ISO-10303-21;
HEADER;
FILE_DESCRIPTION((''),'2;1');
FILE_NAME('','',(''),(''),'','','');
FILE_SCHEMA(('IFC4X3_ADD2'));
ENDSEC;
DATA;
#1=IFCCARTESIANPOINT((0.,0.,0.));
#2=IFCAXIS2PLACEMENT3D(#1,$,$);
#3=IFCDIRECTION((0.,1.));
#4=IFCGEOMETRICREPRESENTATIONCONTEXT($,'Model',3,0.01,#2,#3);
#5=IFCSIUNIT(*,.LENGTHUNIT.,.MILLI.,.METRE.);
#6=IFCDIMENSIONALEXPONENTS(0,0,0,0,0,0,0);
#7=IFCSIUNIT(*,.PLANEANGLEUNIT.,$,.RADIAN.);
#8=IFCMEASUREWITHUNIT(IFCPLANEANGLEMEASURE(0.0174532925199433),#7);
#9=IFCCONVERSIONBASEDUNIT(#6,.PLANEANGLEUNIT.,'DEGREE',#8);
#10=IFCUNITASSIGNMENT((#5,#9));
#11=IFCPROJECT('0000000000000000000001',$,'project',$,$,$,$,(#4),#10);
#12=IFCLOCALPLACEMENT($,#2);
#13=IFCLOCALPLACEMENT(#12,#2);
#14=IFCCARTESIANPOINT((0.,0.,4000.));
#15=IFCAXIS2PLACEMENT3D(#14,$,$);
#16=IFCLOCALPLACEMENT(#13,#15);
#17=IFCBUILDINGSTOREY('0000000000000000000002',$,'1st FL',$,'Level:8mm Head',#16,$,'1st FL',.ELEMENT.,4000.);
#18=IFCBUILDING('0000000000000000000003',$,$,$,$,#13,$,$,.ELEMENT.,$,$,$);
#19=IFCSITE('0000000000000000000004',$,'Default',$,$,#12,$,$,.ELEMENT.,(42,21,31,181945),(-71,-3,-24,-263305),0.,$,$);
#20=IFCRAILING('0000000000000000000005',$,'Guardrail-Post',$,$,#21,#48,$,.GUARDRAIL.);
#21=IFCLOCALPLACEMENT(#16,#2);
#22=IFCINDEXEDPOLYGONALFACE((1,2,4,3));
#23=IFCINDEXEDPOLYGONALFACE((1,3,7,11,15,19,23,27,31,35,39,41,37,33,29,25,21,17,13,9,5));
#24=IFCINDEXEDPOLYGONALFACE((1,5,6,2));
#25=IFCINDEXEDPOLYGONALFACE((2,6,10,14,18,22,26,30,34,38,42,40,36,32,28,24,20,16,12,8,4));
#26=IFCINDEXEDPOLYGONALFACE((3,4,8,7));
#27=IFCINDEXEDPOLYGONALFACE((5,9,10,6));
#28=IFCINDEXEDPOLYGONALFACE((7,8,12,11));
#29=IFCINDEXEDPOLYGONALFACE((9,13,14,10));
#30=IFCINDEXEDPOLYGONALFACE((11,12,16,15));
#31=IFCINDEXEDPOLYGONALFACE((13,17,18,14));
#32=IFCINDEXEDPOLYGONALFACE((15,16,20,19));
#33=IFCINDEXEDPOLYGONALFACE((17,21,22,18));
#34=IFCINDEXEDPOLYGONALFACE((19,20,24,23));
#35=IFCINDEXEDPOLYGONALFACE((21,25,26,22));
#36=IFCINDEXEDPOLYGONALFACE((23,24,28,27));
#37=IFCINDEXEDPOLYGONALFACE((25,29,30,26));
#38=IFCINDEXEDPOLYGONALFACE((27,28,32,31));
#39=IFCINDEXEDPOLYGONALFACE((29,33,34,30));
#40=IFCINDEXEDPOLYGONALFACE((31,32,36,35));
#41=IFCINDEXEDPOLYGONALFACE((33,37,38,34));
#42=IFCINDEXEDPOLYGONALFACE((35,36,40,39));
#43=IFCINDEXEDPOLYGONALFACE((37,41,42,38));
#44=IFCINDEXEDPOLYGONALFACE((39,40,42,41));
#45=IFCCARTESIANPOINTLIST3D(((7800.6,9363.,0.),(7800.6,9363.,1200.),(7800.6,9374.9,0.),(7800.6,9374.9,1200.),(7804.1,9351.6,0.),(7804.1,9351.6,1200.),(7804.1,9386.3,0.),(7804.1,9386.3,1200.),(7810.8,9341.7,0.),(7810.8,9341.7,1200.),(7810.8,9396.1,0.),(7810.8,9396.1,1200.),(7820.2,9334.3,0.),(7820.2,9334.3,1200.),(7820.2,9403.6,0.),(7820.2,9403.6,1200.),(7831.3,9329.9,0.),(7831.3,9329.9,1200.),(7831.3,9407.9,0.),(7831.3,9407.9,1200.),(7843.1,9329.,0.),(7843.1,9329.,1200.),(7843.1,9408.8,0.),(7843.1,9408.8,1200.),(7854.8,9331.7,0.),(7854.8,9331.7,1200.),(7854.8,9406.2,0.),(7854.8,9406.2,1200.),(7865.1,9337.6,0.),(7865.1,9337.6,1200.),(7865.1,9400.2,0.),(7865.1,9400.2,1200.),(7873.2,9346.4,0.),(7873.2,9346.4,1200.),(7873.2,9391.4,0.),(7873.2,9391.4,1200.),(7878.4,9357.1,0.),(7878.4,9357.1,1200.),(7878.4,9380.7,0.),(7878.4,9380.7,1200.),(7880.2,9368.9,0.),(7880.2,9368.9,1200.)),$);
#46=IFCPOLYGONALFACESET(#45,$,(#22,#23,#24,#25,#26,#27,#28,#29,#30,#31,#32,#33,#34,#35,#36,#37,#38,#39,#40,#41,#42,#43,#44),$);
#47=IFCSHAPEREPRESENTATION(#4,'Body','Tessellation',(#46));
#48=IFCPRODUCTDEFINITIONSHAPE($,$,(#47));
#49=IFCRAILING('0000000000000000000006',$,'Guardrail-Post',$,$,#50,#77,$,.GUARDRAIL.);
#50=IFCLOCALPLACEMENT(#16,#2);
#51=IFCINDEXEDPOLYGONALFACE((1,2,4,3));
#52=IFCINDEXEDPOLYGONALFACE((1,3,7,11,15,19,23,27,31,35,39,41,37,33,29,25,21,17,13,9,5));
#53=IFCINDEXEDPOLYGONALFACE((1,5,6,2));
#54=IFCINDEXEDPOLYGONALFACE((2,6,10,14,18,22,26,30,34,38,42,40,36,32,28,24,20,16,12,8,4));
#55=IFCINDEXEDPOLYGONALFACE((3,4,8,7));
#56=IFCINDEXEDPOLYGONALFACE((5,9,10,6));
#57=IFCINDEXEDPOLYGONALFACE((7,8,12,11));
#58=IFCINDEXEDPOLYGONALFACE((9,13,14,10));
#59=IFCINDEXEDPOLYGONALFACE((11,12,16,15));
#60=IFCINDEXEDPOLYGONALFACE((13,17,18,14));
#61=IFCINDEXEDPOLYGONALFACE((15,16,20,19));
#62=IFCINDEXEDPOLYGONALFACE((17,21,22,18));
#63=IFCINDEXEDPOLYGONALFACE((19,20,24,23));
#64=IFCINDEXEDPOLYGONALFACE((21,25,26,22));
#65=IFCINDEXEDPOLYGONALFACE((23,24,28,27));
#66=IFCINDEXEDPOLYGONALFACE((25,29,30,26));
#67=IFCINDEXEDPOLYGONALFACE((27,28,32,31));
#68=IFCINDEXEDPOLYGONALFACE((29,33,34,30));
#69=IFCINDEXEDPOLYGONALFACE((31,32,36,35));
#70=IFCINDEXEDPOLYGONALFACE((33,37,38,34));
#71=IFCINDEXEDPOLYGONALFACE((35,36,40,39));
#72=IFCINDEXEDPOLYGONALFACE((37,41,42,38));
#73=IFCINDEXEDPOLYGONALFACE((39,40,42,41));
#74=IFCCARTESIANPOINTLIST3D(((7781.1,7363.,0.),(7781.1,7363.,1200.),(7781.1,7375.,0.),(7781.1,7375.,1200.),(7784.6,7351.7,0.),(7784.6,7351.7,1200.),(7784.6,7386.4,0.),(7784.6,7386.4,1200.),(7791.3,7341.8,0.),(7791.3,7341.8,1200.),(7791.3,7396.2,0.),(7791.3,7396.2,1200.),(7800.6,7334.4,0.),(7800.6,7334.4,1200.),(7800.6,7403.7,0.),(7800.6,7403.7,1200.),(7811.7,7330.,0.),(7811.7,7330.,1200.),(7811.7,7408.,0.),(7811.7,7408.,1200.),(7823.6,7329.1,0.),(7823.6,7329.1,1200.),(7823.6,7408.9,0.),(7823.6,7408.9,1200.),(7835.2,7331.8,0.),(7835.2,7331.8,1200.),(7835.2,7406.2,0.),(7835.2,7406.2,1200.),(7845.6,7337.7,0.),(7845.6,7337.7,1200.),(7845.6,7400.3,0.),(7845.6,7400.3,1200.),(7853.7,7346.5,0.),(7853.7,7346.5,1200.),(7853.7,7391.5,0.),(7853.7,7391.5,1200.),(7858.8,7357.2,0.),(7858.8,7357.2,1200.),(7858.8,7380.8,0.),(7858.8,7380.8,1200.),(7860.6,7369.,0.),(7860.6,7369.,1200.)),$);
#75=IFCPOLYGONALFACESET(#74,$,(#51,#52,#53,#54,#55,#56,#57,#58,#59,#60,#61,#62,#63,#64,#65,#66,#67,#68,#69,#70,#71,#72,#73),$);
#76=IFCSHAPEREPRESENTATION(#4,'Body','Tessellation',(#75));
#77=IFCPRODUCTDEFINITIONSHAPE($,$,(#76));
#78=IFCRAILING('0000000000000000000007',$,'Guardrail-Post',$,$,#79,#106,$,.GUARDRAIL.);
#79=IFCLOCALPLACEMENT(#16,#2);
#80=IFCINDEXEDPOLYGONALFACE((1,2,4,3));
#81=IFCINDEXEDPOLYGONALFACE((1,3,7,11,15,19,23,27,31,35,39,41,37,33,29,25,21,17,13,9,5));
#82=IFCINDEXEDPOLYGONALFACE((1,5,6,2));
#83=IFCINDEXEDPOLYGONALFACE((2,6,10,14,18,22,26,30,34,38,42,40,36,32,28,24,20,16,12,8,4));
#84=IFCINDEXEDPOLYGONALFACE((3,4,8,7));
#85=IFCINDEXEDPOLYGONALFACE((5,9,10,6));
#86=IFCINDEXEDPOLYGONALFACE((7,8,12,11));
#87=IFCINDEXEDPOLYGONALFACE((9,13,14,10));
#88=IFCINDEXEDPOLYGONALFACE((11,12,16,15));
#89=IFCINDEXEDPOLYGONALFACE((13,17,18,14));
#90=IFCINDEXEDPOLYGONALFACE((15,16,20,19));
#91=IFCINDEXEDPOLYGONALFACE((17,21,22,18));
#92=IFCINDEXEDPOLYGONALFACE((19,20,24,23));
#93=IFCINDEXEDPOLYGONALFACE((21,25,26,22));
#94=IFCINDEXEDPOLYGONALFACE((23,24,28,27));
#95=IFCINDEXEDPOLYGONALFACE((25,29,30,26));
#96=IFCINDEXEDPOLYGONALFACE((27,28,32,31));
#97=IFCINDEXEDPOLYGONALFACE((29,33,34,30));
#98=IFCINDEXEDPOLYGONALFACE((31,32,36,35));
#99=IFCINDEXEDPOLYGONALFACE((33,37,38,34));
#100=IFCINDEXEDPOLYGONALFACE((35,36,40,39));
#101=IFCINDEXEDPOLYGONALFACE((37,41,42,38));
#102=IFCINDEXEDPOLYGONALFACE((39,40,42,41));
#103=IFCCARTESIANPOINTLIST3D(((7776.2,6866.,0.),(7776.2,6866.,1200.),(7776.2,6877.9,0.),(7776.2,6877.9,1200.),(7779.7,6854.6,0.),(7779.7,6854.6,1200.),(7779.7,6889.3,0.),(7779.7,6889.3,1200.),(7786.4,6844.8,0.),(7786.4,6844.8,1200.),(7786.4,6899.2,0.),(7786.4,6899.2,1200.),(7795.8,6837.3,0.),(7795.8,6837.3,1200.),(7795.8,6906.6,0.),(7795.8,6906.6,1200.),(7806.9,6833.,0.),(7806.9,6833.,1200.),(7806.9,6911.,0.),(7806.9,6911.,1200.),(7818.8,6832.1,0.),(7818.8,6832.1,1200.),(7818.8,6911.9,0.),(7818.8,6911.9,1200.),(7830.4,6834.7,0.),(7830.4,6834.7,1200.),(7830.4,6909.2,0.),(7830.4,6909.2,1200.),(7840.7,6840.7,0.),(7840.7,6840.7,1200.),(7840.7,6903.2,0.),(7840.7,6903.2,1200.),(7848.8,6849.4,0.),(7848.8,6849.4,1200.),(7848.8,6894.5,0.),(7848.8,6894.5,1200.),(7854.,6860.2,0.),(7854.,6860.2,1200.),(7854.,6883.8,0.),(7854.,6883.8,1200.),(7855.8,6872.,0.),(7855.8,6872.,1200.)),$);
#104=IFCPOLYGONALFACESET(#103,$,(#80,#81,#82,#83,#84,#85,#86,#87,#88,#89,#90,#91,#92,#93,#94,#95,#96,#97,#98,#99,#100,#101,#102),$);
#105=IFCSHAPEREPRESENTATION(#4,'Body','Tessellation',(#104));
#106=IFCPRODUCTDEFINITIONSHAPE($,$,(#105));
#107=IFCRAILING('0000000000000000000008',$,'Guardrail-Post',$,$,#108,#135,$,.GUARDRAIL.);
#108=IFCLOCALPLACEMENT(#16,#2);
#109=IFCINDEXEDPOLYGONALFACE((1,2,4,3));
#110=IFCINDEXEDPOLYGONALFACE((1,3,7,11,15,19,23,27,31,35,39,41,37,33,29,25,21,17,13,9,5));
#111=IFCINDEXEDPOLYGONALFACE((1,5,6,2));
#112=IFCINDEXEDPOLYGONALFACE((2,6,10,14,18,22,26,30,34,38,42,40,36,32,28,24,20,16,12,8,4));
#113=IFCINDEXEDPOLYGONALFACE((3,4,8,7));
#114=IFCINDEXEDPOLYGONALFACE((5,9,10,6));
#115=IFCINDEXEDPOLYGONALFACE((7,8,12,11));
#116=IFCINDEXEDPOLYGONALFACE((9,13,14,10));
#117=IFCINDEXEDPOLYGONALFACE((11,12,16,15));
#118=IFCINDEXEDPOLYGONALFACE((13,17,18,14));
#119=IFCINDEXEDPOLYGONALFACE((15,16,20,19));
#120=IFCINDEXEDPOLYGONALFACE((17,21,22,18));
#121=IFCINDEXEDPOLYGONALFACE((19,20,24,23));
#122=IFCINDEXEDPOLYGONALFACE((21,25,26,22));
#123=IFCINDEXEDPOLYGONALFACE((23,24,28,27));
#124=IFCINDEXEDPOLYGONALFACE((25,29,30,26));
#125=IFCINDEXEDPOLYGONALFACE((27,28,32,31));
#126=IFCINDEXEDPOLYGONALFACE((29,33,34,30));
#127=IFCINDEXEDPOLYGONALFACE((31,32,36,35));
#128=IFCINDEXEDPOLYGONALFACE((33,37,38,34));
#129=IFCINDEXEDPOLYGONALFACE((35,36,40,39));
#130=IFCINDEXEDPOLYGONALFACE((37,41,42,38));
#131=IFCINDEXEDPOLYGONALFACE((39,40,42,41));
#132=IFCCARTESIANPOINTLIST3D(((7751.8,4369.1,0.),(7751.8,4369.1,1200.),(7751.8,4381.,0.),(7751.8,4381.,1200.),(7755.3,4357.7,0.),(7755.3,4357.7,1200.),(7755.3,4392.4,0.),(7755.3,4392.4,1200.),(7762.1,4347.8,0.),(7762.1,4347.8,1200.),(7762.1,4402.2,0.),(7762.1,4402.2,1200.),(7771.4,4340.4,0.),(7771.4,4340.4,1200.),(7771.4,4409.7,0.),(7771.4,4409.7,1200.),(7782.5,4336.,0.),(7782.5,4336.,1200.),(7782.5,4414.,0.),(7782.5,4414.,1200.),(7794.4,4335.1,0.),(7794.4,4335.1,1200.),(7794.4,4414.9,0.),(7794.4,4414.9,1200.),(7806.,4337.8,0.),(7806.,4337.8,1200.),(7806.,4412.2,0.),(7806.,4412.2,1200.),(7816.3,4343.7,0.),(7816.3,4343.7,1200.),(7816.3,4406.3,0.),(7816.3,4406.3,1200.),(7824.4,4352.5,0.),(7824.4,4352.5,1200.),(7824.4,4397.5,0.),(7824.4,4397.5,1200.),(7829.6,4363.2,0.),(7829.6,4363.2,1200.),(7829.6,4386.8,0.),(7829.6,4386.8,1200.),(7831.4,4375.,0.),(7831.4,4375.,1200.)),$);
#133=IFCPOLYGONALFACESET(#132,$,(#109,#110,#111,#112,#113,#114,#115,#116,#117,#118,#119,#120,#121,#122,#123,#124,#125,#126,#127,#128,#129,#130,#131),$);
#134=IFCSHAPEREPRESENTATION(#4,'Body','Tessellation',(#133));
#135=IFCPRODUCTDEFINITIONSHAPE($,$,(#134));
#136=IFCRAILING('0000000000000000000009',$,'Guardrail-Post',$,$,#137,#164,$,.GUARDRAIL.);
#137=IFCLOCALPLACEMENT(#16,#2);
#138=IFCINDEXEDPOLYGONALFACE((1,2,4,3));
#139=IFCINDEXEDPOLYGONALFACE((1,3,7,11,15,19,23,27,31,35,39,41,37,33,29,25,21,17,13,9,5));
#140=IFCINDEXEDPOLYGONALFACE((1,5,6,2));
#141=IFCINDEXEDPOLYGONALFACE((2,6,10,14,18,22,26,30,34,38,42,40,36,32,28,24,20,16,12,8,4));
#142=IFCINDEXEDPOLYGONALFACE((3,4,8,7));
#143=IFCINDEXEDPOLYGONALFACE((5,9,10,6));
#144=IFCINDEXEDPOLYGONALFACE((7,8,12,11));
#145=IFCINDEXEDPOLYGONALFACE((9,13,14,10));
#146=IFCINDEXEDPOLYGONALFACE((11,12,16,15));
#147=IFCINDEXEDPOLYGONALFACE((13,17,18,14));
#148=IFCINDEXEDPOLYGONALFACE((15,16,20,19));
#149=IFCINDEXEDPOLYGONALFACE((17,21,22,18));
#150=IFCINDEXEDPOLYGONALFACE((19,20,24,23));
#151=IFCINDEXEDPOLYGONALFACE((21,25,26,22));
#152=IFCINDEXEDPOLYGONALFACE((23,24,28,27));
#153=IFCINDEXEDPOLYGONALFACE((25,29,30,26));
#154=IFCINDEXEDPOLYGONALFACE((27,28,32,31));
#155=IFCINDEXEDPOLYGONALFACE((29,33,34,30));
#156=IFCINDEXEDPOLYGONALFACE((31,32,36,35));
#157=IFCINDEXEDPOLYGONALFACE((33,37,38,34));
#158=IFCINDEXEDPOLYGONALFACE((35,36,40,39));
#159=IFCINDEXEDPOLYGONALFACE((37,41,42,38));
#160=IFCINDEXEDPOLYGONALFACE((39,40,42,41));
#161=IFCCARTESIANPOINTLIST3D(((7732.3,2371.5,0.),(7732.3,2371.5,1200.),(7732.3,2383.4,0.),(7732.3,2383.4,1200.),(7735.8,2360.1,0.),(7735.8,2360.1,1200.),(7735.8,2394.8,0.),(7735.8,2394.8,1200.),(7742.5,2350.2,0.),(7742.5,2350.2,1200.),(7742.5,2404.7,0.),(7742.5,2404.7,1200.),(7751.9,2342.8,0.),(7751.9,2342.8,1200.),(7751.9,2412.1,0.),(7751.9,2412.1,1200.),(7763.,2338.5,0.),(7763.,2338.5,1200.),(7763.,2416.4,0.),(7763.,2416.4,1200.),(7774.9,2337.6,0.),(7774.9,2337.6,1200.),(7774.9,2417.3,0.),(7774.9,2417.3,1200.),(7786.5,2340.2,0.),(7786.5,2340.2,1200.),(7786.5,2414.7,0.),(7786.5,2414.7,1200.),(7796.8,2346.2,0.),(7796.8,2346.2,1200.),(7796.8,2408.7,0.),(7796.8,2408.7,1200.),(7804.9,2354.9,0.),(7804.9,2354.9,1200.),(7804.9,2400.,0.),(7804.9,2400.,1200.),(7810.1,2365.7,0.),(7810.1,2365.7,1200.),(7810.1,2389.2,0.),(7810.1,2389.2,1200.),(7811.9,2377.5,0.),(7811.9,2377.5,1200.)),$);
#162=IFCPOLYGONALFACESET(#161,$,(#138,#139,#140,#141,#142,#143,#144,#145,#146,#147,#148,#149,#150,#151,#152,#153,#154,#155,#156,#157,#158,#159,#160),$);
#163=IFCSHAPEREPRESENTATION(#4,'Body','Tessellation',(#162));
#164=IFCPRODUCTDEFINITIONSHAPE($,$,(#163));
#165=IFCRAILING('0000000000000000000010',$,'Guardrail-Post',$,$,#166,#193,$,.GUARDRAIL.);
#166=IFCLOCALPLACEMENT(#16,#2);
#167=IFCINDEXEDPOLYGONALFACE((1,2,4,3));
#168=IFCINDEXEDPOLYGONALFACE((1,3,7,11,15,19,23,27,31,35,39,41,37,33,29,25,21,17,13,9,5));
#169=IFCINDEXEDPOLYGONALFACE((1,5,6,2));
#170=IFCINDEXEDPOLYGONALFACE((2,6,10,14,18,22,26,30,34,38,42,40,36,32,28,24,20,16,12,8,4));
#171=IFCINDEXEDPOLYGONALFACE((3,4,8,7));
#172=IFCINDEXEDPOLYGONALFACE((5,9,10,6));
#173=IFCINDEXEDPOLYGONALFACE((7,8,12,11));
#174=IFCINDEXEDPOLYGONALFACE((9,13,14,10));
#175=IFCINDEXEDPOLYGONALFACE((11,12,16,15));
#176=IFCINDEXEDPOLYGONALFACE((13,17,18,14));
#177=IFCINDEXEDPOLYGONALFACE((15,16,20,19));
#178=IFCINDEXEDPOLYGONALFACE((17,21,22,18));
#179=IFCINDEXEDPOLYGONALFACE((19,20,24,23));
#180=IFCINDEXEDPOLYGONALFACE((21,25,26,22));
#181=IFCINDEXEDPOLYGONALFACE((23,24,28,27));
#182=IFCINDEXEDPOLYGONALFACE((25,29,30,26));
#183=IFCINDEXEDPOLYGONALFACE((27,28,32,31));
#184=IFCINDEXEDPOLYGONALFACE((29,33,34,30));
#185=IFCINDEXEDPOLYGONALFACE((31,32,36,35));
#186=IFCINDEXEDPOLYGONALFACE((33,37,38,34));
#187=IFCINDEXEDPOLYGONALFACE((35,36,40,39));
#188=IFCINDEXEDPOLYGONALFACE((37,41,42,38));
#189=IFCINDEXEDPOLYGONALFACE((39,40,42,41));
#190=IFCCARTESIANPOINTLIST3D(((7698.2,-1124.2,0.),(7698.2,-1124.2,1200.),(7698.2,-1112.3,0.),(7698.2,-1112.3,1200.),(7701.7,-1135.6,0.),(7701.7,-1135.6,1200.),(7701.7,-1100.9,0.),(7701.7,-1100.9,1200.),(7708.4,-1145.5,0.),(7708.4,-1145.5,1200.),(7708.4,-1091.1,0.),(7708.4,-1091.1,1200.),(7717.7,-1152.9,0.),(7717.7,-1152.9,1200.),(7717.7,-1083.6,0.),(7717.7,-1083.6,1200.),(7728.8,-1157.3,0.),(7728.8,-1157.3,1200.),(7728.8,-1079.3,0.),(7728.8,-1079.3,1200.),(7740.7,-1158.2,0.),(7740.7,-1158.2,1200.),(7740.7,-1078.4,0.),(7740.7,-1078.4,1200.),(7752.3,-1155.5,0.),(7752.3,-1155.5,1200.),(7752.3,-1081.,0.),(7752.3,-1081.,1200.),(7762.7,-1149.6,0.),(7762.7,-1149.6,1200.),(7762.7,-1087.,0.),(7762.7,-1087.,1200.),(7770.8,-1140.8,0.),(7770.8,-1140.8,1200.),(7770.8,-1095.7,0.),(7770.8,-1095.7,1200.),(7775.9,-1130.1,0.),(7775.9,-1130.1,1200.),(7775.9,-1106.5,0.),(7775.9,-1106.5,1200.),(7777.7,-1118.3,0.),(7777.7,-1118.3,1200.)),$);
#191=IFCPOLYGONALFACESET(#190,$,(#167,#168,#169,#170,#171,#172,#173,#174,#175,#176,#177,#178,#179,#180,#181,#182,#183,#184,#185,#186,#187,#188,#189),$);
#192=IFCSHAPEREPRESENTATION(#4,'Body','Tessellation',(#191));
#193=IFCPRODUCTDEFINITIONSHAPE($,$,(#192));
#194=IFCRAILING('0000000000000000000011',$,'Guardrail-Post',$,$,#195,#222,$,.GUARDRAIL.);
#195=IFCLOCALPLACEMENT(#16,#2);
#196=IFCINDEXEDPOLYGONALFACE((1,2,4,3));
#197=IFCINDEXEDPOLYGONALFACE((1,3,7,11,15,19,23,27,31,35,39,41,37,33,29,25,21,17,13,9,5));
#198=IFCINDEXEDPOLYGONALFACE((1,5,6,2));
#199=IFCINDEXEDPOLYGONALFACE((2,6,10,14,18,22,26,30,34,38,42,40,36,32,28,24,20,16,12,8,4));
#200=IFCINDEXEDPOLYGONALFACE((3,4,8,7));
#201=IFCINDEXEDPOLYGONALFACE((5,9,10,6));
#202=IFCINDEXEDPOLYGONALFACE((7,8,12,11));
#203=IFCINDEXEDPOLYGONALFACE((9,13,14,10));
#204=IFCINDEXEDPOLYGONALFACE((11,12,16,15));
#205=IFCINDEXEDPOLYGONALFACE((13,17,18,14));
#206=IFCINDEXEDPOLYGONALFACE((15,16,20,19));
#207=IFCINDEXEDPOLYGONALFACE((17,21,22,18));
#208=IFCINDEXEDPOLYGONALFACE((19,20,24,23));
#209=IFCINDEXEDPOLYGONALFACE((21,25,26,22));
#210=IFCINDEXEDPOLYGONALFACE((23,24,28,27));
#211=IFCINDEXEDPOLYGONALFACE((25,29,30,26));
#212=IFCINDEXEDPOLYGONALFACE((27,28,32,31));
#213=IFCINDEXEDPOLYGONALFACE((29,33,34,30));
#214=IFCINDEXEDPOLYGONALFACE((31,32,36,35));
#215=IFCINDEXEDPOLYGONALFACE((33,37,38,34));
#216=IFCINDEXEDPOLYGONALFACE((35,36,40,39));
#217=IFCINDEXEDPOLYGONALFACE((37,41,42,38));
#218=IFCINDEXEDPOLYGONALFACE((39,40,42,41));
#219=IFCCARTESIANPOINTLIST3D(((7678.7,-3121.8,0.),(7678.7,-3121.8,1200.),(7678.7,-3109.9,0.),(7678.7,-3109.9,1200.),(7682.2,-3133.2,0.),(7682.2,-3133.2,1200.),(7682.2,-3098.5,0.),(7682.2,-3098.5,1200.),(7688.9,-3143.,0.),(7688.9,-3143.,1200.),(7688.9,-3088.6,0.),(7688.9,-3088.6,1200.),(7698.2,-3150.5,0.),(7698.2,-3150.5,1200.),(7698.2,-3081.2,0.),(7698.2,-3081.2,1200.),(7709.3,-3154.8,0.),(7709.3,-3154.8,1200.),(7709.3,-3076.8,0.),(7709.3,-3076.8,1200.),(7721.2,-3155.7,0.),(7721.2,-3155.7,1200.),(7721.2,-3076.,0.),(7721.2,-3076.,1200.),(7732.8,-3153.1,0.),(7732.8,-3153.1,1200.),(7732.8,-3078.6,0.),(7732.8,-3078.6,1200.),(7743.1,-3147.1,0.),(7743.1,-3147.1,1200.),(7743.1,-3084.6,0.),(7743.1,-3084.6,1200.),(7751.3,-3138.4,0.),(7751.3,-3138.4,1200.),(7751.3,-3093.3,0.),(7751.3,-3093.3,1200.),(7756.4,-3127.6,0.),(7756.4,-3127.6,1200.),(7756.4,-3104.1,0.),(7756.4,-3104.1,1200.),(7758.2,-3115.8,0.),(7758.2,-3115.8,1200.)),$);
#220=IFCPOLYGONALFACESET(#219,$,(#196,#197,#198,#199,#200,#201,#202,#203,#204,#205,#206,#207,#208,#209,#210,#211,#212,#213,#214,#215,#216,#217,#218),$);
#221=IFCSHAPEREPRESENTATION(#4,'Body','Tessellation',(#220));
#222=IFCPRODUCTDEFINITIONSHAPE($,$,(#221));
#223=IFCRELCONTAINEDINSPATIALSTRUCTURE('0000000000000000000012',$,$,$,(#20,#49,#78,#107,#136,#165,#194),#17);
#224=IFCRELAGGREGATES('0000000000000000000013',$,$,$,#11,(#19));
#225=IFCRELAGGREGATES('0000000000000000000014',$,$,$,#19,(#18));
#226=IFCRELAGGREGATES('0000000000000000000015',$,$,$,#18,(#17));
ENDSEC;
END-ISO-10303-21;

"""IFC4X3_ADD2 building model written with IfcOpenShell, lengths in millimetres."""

from ifc_helpers import new_model, entity, si_unit, converted_unit, direction, frame, origin, origin_with_axes, origin_2d, place, context, project, spatial, circle, extrude, element, save


model = new_model("IFC4X3_ADD2")

# Units and contexts
model_context = context("Model", 3, precision=0.01, world=origin(), true_north=direction((0.0, 1.0)))
ifc_project = project(units=[si_unit("LENGTHUNIT", "METRE", prefix="MILLI"), converted_unit("PLANEANGLEUNIT", "DEGREE", entity("IfcPlaneAngleMeasure", 0.0174532925199433), si_unit("PLANEANGLEUNIT", "RADIAN"), dimensions=[0, 0, 0, 0, 0, 0, 0])], contexts=[model_context])

# Site, building, storey
site_placement = place(None, origin())
site = spatial("IfcSite", under=ifc_project, at=site_placement, Name="Default", CompositionType="ELEMENT", RefLatitude=(42, 21, 31, 181945), RefLongitude=(-71, -3, -24, -263305), RefElevation=0.0)
building_placement = place(site_placement, origin())
building = spatial("IfcBuilding", under=site, at=building_placement, CompositionType="ELEMENT")
storey_placement = place(building_placement, frame((0.0, 0.0, 4000.0)))
storey = spatial("IfcBuildingStorey", under=building, at=storey_placement, Name="1st FL", ObjectType="Level:8mm Head", LongName="1st FL", CompositionType="ELEMENT", Elevation=4000.0)

# Railings
for number, where, z_axis, x_axis, name in (
    (1, (7840.2, 9368.9, 4000.0), (0.0, 0.0, 1.0), (1.0, 0.0, 0.0), "Guardrail-Post"),
    (2, (7820.6, 7369.0, 4000.0), (0.0, 0.0, 1.0), (1.0, 0.0, 0.0), "Guardrail-Post"),
    (3, (7815.8, 6872.0, 4000.0), (0.0, 0.0, 1.0), (1.0, 0.0, 0.0), "Guardrail-Post"),
):
    element("IfcRailing", number, at=place(None, frame(where, z_axis=z_axis, x_axis=x_axis)), inside=storey, Name=name, PredefinedType="GUARDRAIL", context=model_context, shape_type="SweptSolid", body=[
        extrude(circle(Radius=40.0, at=origin_2d()), origin_with_axes(), (0.0, 0.0, 1.0), 1200.0),
    ])
for number, where, z_axis, x_axis, name in (
    (4, (7791.4, 4375.0, 4000.0), (0.0, 0.0, 1.0), (1.0, 0.0, 0.0), "Guardrail-Post"),
    (5, (7771.9, 2377.5, 4000.0), (0.0, 0.0, 1.0), (1.0, 0.0, 0.0), "Guardrail-Post"),
):
    element("IfcRailing", number, at=place(None, frame(where, z_axis=z_axis, x_axis=x_axis)), inside=storey, Name=name, PredefinedType="GUARDRAIL", context=model_context, shape_type="SweptSolid", body=[
        extrude(circle(Radius=40.0, at=origin_2d()), origin_with_axes(), (0.0, 0.0, 1.0), 1200.0),
    ])
for number, where, z_axis, x_axis, name in (
    (6, (7737.7, -1118.3, 4000.0), (0.0, 0.0, 1.0), (1.0, 0.0, 0.0), "Guardrail-Post"),
    (7, (7718.2, -3115.8, 4000.0), (0.0, 0.0, 1.0), (1.0, 0.0, 0.0), "Guardrail-Post"),
):
    element("IfcRailing", number, at=place(None, frame(where, z_axis=z_axis, x_axis=x_axis)), inside=storey, Name=name, PredefinedType="GUARDRAIL", context=model_context, shape_type="SweptSolid", body=[
        extrude(circle(Radius=40.0, at=origin_2d()), origin_with_axes(), (0.0, 0.0, 1.0), 1200.0),
    ])

save(model, "model.ifc")
